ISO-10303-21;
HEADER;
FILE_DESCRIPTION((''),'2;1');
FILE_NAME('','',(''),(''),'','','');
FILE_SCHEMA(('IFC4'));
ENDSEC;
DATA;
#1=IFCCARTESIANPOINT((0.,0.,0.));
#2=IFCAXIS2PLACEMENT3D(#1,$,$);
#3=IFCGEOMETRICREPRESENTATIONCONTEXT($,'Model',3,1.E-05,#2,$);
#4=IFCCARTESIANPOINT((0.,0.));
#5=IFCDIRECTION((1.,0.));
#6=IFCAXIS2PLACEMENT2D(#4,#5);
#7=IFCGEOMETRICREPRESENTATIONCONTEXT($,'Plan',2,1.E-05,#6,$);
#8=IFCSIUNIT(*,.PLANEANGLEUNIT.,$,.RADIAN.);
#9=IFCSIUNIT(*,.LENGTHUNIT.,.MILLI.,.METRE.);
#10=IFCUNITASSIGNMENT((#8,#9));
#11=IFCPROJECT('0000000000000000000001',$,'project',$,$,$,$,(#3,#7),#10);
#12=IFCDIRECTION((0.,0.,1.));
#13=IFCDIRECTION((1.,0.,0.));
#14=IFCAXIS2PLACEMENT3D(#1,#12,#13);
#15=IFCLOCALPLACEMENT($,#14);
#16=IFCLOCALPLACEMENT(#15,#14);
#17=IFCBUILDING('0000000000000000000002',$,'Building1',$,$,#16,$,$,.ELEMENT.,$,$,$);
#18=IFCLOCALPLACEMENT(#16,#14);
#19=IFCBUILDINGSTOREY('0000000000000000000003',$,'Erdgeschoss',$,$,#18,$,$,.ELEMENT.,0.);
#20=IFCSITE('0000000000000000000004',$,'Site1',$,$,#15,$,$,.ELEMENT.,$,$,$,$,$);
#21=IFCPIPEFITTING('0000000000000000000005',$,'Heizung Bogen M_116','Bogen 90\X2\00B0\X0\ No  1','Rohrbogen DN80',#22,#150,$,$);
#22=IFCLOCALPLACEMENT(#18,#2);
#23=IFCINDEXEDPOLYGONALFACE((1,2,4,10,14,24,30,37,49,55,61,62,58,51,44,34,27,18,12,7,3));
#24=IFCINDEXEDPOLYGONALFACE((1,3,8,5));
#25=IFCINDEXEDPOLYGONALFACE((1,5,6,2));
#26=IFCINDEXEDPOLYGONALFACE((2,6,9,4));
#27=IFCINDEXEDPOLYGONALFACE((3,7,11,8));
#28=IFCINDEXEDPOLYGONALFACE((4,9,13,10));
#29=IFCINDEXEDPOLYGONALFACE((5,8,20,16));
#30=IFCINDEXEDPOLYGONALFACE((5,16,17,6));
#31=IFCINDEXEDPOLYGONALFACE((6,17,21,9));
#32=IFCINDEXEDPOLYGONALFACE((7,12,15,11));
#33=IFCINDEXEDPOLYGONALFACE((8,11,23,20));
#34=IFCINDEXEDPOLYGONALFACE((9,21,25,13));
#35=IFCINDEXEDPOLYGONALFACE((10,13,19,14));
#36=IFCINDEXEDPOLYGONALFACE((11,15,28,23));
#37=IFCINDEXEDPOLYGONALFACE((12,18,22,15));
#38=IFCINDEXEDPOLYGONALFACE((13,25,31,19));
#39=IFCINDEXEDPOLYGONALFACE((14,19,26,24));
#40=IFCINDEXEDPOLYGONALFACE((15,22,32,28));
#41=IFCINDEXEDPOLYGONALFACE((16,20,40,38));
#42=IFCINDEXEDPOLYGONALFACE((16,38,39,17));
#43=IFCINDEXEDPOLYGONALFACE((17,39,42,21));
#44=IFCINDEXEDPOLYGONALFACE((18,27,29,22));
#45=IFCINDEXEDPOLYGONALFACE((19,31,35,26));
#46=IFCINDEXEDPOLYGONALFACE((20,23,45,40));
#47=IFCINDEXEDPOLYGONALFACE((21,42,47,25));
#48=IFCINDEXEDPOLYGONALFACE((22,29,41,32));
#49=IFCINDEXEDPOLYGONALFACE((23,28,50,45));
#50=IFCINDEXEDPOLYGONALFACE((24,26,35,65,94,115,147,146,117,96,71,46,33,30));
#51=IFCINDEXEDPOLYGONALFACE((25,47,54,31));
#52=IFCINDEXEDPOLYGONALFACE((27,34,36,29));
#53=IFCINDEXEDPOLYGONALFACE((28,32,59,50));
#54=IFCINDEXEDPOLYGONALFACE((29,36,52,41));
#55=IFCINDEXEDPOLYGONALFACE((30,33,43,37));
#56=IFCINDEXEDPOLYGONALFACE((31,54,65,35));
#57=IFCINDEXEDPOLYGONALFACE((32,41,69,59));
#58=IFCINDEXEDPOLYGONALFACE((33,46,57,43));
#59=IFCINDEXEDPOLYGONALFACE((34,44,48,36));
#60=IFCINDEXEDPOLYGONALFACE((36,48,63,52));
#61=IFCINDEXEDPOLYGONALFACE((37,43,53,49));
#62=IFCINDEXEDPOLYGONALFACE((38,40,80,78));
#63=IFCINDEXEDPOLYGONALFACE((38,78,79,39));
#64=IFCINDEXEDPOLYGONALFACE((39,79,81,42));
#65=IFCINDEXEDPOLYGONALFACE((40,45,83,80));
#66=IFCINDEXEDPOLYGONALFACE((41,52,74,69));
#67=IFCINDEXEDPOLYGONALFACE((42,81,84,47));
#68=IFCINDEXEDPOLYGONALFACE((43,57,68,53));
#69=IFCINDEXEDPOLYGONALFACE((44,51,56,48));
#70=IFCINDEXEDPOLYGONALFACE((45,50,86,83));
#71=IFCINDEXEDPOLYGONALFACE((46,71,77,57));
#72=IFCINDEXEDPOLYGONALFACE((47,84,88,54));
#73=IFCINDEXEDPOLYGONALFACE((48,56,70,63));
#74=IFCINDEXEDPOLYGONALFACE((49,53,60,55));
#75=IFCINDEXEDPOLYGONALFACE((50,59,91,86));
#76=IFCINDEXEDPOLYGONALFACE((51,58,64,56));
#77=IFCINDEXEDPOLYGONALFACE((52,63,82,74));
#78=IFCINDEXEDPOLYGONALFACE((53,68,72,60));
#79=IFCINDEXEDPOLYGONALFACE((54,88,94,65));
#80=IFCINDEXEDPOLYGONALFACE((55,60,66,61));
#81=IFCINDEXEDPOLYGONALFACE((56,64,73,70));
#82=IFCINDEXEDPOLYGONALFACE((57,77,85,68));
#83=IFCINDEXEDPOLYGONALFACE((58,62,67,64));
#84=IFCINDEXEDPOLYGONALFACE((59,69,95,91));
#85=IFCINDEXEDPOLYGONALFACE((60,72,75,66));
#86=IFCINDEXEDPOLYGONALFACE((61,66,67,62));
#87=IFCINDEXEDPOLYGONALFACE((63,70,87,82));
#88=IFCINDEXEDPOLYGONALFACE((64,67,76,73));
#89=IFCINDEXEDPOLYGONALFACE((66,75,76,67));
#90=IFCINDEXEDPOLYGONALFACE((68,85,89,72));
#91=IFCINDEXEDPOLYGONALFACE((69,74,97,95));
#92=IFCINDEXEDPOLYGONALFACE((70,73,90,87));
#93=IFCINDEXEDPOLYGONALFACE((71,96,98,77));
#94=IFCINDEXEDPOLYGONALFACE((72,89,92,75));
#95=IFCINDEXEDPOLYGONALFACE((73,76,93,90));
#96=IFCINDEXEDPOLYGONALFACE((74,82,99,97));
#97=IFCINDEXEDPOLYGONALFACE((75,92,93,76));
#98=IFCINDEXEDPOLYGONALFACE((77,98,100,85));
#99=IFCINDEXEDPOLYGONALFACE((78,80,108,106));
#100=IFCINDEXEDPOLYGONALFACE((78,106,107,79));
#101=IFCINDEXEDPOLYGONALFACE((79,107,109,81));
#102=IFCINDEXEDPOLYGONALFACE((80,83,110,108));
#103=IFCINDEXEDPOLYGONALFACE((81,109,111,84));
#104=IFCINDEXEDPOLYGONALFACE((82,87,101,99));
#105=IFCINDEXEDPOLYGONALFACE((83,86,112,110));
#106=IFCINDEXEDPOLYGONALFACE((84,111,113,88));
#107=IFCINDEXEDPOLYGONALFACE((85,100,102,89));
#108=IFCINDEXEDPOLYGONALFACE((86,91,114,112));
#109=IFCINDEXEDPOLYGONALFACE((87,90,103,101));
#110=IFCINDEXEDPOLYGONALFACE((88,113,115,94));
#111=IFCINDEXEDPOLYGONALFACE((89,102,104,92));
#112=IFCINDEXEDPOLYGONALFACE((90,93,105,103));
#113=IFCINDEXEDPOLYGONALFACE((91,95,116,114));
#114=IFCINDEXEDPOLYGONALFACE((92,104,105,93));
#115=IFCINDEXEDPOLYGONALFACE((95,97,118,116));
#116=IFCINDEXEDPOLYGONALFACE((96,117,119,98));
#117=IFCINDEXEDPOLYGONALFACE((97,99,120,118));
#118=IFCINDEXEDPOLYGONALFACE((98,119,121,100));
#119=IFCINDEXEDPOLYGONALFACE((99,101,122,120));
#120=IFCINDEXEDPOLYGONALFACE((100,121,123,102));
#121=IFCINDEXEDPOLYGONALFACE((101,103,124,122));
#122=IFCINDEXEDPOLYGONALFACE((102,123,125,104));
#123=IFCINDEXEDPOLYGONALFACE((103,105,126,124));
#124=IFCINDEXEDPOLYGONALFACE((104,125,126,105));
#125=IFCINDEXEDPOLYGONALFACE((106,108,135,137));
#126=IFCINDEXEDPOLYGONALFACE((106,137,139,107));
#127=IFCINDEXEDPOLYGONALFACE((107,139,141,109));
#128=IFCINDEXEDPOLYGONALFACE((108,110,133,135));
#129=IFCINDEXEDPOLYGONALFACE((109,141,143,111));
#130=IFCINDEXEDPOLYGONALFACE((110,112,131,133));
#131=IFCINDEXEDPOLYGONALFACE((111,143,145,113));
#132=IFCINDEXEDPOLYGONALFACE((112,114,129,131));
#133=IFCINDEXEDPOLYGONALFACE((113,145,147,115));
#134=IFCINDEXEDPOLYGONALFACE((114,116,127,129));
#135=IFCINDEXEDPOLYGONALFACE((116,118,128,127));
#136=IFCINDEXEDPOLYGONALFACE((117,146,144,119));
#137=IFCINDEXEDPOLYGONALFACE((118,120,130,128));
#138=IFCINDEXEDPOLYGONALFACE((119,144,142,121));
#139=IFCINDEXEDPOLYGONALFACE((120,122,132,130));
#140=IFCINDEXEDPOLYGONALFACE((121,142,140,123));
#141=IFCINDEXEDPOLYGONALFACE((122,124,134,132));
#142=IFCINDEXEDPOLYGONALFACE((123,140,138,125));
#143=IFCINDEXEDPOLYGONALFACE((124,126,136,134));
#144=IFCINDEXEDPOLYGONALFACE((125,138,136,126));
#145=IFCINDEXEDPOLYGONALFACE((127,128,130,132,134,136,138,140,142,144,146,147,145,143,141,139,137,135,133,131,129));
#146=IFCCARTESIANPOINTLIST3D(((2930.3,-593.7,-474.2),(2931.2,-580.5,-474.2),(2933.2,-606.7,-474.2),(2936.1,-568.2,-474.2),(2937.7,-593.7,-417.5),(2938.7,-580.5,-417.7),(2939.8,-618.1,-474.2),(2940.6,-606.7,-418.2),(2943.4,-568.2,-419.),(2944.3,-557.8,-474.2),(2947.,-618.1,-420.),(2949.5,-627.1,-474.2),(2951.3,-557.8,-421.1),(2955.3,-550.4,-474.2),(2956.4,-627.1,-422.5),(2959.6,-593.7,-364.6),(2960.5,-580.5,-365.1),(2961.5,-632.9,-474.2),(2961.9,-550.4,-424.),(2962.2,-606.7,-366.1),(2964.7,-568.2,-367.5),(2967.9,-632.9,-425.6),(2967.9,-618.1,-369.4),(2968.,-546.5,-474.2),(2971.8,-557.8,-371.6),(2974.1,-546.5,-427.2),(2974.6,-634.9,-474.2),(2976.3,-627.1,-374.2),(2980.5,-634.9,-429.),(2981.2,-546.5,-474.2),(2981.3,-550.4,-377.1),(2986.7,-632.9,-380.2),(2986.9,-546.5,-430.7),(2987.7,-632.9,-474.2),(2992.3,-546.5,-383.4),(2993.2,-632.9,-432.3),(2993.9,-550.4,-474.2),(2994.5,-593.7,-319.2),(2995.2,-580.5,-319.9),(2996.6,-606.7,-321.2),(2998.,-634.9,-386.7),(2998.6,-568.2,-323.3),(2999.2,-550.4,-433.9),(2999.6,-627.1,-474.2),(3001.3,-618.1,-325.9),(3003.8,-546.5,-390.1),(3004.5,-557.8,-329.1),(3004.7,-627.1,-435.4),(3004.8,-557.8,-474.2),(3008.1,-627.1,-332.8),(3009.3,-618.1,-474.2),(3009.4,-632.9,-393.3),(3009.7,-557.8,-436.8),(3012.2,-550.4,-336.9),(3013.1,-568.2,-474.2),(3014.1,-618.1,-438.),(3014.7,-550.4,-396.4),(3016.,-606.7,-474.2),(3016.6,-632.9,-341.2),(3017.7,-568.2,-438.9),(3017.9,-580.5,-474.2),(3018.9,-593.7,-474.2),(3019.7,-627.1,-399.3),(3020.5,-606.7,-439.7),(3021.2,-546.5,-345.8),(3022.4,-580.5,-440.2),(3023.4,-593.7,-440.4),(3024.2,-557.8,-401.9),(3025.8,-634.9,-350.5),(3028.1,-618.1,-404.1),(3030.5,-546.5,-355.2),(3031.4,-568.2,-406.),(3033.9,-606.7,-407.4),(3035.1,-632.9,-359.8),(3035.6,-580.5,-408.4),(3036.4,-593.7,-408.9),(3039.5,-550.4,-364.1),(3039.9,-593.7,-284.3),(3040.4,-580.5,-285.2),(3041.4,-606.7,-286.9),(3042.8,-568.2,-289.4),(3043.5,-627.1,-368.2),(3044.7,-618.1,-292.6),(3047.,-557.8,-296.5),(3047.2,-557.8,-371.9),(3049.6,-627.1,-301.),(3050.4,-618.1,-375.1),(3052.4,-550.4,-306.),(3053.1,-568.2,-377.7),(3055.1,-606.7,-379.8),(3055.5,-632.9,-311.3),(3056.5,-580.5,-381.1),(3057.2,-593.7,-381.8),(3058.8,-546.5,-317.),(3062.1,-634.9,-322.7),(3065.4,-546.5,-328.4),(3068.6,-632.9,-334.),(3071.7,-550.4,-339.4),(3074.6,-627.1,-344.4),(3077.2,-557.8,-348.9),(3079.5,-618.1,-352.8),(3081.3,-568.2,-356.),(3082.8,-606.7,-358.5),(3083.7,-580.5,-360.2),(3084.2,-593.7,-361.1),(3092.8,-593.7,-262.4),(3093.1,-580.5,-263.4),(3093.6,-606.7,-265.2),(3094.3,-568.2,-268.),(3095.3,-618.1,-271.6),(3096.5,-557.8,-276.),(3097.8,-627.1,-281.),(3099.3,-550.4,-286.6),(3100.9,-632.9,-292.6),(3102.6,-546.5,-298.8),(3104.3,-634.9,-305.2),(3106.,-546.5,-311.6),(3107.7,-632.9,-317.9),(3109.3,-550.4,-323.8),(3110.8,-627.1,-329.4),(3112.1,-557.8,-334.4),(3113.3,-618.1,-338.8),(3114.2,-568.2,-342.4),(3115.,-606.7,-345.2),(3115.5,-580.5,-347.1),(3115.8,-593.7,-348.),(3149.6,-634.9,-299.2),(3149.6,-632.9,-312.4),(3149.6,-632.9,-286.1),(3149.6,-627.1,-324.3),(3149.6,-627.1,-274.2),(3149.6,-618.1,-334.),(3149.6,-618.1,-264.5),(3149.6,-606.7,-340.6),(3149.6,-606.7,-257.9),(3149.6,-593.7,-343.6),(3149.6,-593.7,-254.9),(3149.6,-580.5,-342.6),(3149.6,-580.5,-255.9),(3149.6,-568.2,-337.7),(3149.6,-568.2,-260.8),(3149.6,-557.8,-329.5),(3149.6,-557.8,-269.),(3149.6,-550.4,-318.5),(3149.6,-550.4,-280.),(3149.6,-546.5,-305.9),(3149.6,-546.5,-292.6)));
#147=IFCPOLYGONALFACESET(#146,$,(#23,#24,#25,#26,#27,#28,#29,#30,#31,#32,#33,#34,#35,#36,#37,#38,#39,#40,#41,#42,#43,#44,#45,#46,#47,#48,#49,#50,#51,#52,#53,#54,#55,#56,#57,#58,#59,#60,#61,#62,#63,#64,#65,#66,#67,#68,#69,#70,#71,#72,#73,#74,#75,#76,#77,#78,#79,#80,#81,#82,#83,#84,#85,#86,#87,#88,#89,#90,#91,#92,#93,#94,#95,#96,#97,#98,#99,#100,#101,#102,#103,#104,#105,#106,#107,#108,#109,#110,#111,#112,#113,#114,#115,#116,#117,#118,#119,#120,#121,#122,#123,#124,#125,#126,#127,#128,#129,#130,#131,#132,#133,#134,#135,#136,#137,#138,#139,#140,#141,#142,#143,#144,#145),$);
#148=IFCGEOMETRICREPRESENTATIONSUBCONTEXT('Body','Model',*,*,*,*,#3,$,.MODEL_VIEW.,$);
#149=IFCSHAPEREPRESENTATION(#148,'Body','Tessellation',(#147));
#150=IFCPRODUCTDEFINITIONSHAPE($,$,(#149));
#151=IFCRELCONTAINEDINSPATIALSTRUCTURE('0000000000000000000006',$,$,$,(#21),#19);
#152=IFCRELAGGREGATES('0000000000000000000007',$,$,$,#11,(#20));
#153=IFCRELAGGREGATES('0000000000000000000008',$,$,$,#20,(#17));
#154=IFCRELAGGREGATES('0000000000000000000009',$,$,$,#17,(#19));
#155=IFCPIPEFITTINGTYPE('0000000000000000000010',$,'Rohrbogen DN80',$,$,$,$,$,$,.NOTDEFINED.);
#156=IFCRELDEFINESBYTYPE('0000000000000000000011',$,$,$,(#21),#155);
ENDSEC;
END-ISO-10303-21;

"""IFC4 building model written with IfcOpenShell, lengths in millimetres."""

from ifc_helpers import new_model, entity, si_unit, frame, origin, origin_with_axes, origin_2d_with_axis, place, context, subcontext, project, spatial, shape, source, transform, mapped, type_object, element, save


model = new_model("IFC4")

# Units and contexts
model_context = context("Model", 3, precision=1e-05, world=origin())
plan_context = context("Plan", 2, precision=1e-05, world=origin_2d_with_axis())
body_context = subcontext(model_context, "Body", "Model", "MODEL_VIEW")
ifc_project = project(units=[si_unit("PLANEANGLEUNIT", "RADIAN"), si_unit("LENGTHUNIT", "METRE", prefix="MILLI")], contexts=[model_context, plan_context])

# Site, building, storey
site_placement = place(None, origin_with_axes())
site = spatial("IfcSite", under=ifc_project, at=site_placement, Name="Site1", CompositionType="ELEMENT")
building_placement = place(site_placement, origin_with_axes())
building = spatial("IfcBuilding", under=site, at=building_placement, Name="Building1", CompositionType="ELEMENT")
storey_placement = place(building_placement, origin_with_axes())
storey = spatial("IfcBuildingStorey", under=building, at=storey_placement, Name="Erdgeschoss", CompositionType="ELEMENT", Elevation=0.0)

# Pipe fitting
pipe_fitting_type_1 = type_object("IfcPipeFittingType", Name="Rohrbogen DN80", PredefinedType="NOTDEFINED")
ifc_direction_1 = entity("IfcDirection", [-1.0, 0.0, 0.0])
shared_shape_1 = source(origin_with_axes(), body_context, "Body", "SolidModel", [
    entity("IfcRevolvedAreaSolid", entity("IfcCircleProfileDef", "AREA", None, entity("IfcAxis2Placement2D", entity("IfcCartesianPoint", [0.0, 0.0]), entity("IfcDirection", [1.0, 0.0])), 44.5), entity("IfcAxis2Placement3D", entity("IfcCartesianPoint", [109.7, -65.3, 0.0]), ifc_direction_1, entity("IfcDirection", [0.0, 0.0, 1.0])), entity("IfcAxis1Placement", entity("IfcCartesianPoint", [0.0, 175.0, 0.0]), ifc_direction_1), 1.570796),
])
pipe_fitting_1_placement = place(storey_placement, frame((3039.9, -590.4, -364.5), z_axis=(0.0, 0.0, 1.0), x_axis=(1.0, 0.0, 0.0)))
element("IfcPipeFitting", 1, at=pipe_fitting_1_placement, inside=storey, type_object=pipe_fitting_type_1, Name="Heizung Bogen M_116", Description="Bogen 90° No  1", ObjectType="Rohrbogen DN80", shapes=[
    shape(body_context, "Body", "MappedRepresentation", [mapped(shared_shape_1, transform((0.0, 0.0, 0.0), x_axis=(0.0, 0.0, -1.0), y_axis=(1.0, 0.0, 0.0), z_axis=(0.0, -1.0, 0.0), scale=1.0))]),
    shape(body_context, "Body", "MappedRepresentation", [mapped(shared_shape_1, transform((0.0, 0.0, 0.0), x_axis=(0.0, 0.0, -1.0), y_axis=(1.0, 0.0, 0.0), z_axis=(0.0, -1.0, 0.0), scale=1.0))]),
])

save(model, "model.ifc")
